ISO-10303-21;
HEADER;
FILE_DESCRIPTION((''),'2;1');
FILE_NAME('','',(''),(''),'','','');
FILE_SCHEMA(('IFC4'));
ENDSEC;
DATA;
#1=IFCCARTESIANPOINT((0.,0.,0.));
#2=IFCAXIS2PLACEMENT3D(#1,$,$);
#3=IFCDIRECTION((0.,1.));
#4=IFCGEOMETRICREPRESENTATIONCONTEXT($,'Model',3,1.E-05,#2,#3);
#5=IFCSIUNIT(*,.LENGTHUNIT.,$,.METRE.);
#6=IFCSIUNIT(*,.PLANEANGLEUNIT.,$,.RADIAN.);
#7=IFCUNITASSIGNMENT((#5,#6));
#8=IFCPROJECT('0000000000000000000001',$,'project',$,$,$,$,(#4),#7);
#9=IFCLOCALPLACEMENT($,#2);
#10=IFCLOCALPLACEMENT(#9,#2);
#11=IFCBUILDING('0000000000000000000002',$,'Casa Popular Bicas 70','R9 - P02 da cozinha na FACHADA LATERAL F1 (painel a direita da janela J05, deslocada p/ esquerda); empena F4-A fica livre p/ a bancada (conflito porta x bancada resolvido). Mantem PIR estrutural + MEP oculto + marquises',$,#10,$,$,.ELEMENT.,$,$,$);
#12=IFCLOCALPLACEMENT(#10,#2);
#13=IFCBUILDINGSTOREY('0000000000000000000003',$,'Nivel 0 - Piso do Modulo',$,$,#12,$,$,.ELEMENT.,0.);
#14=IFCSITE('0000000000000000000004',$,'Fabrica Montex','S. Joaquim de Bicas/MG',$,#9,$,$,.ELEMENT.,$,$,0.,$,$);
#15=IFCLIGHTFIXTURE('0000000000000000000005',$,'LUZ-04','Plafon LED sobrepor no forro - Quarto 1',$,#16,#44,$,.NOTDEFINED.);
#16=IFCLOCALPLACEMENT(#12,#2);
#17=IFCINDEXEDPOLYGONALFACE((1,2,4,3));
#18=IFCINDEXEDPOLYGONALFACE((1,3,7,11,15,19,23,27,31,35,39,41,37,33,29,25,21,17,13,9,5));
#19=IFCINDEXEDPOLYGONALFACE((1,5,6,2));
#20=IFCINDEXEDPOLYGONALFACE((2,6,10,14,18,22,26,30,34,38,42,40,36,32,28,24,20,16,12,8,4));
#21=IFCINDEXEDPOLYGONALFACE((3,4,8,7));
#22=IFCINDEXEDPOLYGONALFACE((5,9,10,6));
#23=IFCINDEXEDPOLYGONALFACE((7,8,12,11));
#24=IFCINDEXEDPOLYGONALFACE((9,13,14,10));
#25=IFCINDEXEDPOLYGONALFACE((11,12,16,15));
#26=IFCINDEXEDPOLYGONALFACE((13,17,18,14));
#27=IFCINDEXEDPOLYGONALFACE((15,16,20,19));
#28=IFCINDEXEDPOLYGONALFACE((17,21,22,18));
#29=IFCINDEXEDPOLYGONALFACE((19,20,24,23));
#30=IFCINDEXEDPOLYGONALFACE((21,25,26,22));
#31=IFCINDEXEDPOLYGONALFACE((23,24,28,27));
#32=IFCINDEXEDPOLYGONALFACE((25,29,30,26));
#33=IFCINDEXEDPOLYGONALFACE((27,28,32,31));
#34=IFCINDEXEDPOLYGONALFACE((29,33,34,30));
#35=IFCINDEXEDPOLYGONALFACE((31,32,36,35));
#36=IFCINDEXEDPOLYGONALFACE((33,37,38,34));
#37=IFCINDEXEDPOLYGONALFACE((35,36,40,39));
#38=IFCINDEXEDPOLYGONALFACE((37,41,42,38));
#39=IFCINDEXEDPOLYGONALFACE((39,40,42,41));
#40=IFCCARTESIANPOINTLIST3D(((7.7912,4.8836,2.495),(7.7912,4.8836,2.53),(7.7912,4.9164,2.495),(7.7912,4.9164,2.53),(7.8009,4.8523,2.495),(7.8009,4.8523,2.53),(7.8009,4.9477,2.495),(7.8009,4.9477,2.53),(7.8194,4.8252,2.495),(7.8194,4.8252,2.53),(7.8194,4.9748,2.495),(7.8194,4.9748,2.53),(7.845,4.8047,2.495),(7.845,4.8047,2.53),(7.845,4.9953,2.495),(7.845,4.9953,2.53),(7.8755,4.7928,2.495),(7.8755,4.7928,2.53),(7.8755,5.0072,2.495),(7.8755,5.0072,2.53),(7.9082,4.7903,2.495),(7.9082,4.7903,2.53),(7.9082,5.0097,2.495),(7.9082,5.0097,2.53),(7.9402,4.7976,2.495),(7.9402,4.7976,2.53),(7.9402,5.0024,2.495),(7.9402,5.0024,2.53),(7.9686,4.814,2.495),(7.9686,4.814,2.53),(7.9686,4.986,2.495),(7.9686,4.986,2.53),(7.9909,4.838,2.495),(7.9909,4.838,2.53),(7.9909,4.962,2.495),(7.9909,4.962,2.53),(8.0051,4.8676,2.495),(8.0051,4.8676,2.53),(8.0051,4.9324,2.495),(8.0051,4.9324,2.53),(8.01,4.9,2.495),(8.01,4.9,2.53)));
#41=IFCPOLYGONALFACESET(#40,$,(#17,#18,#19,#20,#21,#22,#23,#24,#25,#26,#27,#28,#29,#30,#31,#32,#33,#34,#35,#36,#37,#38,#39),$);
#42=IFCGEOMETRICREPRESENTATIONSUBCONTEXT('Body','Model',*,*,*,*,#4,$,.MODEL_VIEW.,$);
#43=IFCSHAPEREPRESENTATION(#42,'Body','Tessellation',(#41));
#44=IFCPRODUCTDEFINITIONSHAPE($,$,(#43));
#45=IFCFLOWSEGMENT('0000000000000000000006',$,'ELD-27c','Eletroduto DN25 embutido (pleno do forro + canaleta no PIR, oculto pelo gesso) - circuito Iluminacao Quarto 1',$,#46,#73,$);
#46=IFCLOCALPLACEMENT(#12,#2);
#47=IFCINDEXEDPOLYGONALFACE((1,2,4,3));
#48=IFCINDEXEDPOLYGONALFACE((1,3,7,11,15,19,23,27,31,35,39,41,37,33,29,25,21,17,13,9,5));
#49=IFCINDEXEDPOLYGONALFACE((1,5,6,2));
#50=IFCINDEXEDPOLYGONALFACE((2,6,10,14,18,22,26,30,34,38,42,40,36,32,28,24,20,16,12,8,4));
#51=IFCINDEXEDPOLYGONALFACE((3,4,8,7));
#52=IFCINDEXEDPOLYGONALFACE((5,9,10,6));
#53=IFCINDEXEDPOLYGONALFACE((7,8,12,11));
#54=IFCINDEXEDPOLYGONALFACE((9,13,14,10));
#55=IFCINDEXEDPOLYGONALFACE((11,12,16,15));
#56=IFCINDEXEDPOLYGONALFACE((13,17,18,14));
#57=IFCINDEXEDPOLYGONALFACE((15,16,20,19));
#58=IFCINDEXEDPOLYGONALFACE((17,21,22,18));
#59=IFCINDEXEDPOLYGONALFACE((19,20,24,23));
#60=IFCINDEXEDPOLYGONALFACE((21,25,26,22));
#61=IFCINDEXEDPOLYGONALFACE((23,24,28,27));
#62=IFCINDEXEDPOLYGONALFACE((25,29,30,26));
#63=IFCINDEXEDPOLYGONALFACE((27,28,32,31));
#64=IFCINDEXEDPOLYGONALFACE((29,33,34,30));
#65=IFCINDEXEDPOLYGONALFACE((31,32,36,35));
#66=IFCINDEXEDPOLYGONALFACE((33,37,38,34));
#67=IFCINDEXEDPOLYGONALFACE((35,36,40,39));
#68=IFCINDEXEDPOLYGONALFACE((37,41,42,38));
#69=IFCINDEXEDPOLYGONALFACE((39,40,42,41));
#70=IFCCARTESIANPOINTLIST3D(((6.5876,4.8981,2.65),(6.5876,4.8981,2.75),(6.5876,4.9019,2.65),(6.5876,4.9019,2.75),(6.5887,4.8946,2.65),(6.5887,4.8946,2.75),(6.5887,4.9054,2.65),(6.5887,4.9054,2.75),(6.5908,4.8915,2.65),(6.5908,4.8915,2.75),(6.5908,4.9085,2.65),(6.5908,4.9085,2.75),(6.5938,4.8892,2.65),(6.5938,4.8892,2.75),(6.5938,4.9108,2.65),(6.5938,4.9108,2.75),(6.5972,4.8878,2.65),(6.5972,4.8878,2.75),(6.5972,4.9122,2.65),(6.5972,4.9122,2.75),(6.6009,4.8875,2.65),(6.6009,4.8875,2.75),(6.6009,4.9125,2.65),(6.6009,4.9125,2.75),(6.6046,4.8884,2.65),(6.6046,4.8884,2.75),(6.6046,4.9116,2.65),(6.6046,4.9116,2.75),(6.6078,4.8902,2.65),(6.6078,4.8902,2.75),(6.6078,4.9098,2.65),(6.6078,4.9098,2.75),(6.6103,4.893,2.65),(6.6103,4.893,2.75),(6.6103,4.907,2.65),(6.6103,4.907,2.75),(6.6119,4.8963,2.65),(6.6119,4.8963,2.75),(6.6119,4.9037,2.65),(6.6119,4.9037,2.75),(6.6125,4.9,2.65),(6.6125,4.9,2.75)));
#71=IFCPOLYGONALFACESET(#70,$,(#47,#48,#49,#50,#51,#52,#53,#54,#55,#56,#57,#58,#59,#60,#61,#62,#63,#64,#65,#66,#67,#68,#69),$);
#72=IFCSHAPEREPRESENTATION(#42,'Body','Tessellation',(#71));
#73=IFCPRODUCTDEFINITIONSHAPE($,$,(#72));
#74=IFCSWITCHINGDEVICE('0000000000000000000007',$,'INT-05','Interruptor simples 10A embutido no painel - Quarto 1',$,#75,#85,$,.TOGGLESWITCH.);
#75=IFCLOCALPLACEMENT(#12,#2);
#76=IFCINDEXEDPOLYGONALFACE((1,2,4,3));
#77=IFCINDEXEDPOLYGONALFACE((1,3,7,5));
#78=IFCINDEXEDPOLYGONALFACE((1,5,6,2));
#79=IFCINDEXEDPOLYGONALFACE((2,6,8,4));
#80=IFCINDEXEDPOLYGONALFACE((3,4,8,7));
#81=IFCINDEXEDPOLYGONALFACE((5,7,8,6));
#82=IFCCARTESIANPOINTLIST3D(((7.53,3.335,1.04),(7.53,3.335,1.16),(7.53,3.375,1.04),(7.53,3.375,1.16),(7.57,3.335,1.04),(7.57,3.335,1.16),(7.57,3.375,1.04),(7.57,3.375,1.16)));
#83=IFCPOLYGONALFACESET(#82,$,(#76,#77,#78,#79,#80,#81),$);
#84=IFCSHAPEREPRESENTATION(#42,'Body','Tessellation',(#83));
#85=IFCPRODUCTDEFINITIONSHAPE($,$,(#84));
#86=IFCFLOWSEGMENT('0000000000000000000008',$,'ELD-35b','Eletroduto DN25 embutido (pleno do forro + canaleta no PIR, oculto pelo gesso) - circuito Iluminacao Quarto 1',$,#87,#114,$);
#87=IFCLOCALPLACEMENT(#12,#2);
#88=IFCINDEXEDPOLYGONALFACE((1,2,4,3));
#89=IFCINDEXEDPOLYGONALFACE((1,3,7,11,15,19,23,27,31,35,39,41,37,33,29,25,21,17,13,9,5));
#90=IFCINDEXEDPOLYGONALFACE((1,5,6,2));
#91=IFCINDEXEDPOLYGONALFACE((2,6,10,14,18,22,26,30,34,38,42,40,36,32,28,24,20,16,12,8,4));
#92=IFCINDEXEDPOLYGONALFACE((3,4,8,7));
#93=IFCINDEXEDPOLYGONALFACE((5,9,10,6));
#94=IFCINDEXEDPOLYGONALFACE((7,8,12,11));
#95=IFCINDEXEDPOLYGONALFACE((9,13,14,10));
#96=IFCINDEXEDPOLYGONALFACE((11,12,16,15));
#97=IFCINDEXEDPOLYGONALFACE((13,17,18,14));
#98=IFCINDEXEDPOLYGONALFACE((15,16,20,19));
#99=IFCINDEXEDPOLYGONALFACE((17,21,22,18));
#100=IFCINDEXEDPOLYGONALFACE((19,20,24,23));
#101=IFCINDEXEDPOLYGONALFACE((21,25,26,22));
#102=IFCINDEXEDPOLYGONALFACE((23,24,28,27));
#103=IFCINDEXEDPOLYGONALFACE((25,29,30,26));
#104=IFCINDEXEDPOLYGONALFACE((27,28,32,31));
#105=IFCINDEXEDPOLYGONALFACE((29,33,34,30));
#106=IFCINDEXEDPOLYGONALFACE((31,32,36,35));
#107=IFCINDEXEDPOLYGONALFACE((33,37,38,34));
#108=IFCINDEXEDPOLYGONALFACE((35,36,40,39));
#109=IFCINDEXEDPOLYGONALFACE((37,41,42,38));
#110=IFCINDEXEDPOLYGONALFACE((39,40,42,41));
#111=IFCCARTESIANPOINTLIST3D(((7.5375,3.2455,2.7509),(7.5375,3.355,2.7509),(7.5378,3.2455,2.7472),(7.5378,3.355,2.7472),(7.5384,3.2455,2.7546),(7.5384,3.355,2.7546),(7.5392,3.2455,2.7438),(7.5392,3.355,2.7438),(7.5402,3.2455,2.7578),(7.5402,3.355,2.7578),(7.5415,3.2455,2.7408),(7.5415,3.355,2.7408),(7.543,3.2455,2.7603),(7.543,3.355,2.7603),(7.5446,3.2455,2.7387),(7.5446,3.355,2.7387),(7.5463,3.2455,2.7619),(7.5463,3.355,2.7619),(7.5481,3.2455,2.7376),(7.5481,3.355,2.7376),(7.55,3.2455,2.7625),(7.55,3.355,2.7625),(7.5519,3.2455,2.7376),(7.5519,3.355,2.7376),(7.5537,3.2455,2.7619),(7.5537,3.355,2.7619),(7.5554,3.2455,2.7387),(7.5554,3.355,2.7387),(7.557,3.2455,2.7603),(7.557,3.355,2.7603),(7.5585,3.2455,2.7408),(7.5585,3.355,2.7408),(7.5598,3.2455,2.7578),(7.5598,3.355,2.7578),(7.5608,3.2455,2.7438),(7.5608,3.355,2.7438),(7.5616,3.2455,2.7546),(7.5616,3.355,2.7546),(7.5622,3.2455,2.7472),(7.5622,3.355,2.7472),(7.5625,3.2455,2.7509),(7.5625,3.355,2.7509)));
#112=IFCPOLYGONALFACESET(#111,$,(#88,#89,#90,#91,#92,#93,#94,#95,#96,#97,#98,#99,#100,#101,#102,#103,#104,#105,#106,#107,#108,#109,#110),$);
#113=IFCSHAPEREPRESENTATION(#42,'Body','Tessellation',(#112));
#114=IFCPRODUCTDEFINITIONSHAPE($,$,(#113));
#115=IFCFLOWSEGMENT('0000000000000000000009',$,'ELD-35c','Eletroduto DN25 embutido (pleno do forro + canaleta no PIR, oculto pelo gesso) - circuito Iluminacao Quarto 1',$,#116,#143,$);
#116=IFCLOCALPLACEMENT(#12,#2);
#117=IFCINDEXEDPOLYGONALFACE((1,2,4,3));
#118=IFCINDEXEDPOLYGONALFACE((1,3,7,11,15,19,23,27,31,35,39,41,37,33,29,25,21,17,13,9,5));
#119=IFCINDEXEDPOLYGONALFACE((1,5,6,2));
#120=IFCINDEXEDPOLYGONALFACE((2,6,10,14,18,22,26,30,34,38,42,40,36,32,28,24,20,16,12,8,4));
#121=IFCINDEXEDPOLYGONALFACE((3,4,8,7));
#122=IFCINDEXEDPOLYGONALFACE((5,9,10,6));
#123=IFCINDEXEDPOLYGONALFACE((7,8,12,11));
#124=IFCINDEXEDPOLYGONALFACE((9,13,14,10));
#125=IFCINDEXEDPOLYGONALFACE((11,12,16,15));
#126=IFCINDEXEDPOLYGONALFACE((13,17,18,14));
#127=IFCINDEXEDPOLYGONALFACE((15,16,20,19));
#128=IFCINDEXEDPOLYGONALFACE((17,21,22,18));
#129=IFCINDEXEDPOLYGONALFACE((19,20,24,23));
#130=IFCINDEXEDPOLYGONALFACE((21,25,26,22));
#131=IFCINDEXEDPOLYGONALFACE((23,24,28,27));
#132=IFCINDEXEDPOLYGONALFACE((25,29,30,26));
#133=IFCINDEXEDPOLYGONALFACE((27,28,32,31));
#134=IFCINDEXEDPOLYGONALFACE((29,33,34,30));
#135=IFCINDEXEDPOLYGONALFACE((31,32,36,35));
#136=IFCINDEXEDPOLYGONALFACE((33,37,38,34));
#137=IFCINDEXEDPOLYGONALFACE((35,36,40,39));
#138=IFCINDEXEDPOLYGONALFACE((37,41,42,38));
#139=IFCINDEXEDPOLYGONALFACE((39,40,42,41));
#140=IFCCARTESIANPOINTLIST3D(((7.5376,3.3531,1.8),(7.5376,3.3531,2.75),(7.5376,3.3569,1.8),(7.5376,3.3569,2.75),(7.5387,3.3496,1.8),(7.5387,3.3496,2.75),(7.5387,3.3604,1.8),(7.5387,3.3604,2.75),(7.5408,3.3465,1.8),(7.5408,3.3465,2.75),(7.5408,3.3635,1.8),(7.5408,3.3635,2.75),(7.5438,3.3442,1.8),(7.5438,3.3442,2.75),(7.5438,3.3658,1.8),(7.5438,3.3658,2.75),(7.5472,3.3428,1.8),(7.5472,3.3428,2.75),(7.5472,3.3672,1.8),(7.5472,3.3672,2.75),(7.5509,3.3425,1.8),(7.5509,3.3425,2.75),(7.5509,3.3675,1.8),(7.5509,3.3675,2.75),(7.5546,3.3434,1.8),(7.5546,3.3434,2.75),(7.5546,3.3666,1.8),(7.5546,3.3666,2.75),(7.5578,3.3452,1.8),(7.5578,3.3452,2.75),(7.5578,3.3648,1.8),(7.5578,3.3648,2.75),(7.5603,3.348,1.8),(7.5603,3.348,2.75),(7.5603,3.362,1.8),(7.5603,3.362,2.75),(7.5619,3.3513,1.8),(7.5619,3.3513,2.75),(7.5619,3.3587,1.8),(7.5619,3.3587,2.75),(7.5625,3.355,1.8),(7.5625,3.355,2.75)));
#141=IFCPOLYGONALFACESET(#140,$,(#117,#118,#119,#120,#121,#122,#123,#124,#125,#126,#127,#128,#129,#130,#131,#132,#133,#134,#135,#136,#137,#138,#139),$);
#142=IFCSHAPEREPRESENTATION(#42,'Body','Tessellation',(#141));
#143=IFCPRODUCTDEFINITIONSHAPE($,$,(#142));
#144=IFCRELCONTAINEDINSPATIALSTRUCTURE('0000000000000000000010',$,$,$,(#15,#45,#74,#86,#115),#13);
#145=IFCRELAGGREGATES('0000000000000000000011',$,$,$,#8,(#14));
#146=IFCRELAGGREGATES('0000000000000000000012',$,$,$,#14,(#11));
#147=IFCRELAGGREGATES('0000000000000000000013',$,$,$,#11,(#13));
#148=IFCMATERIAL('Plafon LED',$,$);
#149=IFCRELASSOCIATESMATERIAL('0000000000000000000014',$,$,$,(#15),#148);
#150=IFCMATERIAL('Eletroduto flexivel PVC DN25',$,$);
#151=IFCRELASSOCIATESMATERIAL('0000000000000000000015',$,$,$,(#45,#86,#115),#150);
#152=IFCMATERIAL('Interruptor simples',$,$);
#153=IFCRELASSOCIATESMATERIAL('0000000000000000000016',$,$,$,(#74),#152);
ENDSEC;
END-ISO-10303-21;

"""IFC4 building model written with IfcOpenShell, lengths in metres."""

from ifc_helpers import new_model, si_unit, direction, frame, frame_2d, origin, origin_2d, place, context, subcontext, project, spatial, rectangle, circle, extrude, material, element, save


model = new_model("IFC4")

# Units and contexts
model_context = context("Model", 3, precision=1e-05, world=origin(), true_north=direction((0.0, 1.0)))
body_context = subcontext(model_context, "Body", "Model", "MODEL_VIEW")
ifc_project = project(units=[si_unit("LENGTHUNIT", "METRE"), si_unit("PLANEANGLEUNIT", "RADIAN")], contexts=[model_context])

# Site, building, storey
site_placement = place(None, origin())
site = spatial("IfcSite", under=ifc_project, at=site_placement, Name="Fabrica Montex", Description="S. Joaquim de Bicas/MG", CompositionType="ELEMENT", RefElevation=0.0)
building_placement = place(site_placement, origin())
building = spatial("IfcBuilding", under=site, at=building_placement, Name="Casa Popular Bicas 70", Description="R9 - P02 da cozinha na FACHADA LATERAL F1 (painel a direita da janela J05, deslocada p/ esquerda); empena F4-A fica livre p/ a bancada (conflito porta x bancada resolvido). Mantem PIR estrutural + MEP oculto + marquises", CompositionType="ELEMENT")
storey_placement = place(building_placement, origin())
storey = spatial("IfcBuildingStorey", under=building, at=storey_placement, Name="Nivel 0 - Piso do Modulo", CompositionType="ELEMENT", Elevation=0.0)

# Shared definitions
ifc_material_1 = material(Name="Eletroduto flexivel PVC DN25")

# Light fixture
ifc_material_2 = material(Name="Plafon LED")
light_fixture_placement = place(storey_placement, frame((7.9, 4.9, 2.495)))
element("IfcLightFixture", 1, at=light_fixture_placement, inside=storey, material=ifc_material_2, Name="LUZ-04", Description="Plafon LED sobrepor no forro - Quarto 1", PredefinedType="NOTDEFINED", context=body_context, shape_type="SweptSolid", body=[
    extrude(circle(Radius=0.11, at=origin_2d()), origin(), (0.0, 0.0, 1.0), 0.035),
])

# Flow segment
for number, where, z_axis, x_axis, name in (
    (2, (6.6, 4.9, 2.75), (0.0, 0.0, -1.0), (1.0, 0.0, 0.0), "ELD-27c"),
):
    element("IfcFlowSegment", number, at=place(storey_placement, frame(where, z_axis=z_axis, x_axis=x_axis)), inside=storey, material=ifc_material_1, Name=name, Description="Eletroduto DN25 embutido (pleno do forro + canaleta no PIR, oculto pelo gesso) - circuito Iluminacao Quarto 1", context=body_context, shape_type="SweptSolid", body=[
        extrude(circle(Radius=0.0125, at=origin_2d()), origin(), (0.0, 0.0, 1.0), 0.1),
    ])

# Switching device
ifc_material_3 = material(Name="Interruptor simples")
switching_device_placement = place(storey_placement, frame((7.53, 3.335, 1.04)))
element("IfcSwitchingDevice", 3, at=switching_device_placement, inside=storey, material=ifc_material_3, Name="INT-05", Description="Interruptor simples 10A embutido no painel - Quarto 1", PredefinedType="TOGGLESWITCH", context=body_context, shape_type="SweptSolid", body=[
    extrude(rectangle(XDim=0.04, YDim=0.04, at=frame_2d((0.02, 0.02))), origin(), (0.0, 0.0, 1.0), 0.12),
])

# Flow segments
flow_segment_1_placement = place(storey_placement, frame((7.55, 3.2455, 2.75), z_axis=(0.0, 1.0, 0.0), x_axis=(0.0, 0.0, 1.0)))
element("IfcFlowSegment", 4, at=flow_segment_1_placement, inside=storey, material=ifc_material_1, Name="ELD-35b", Description="Eletroduto DN25 embutido (pleno do forro + canaleta no PIR, oculto pelo gesso) - circuito Iluminacao Quarto 1", context=body_context, shape_type="SweptSolid", body=[
    extrude(circle(Radius=0.0125, at=origin_2d()), origin(), (0.0, 0.0, 1.0), 0.1095),
])
flow_segment_2_placement = place(storey_placement, frame((7.55, 3.355, 2.75), z_axis=(0.0, 0.0, -1.0), x_axis=(1.0, 0.0, 0.0)))
element("IfcFlowSegment", 5, at=flow_segment_2_placement, inside=storey, material=ifc_material_1, Name="ELD-35c", Description="Eletroduto DN25 embutido (pleno do forro + canaleta no PIR, oculto pelo gesso) - circuito Iluminacao Quarto 1", context=body_context, shape_type="SweptSolid", body=[
    extrude(circle(Radius=0.0125, at=origin_2d()), origin(), (0.0, 0.0, 1.0), 0.95),
])

save(model, "model.ifc")
